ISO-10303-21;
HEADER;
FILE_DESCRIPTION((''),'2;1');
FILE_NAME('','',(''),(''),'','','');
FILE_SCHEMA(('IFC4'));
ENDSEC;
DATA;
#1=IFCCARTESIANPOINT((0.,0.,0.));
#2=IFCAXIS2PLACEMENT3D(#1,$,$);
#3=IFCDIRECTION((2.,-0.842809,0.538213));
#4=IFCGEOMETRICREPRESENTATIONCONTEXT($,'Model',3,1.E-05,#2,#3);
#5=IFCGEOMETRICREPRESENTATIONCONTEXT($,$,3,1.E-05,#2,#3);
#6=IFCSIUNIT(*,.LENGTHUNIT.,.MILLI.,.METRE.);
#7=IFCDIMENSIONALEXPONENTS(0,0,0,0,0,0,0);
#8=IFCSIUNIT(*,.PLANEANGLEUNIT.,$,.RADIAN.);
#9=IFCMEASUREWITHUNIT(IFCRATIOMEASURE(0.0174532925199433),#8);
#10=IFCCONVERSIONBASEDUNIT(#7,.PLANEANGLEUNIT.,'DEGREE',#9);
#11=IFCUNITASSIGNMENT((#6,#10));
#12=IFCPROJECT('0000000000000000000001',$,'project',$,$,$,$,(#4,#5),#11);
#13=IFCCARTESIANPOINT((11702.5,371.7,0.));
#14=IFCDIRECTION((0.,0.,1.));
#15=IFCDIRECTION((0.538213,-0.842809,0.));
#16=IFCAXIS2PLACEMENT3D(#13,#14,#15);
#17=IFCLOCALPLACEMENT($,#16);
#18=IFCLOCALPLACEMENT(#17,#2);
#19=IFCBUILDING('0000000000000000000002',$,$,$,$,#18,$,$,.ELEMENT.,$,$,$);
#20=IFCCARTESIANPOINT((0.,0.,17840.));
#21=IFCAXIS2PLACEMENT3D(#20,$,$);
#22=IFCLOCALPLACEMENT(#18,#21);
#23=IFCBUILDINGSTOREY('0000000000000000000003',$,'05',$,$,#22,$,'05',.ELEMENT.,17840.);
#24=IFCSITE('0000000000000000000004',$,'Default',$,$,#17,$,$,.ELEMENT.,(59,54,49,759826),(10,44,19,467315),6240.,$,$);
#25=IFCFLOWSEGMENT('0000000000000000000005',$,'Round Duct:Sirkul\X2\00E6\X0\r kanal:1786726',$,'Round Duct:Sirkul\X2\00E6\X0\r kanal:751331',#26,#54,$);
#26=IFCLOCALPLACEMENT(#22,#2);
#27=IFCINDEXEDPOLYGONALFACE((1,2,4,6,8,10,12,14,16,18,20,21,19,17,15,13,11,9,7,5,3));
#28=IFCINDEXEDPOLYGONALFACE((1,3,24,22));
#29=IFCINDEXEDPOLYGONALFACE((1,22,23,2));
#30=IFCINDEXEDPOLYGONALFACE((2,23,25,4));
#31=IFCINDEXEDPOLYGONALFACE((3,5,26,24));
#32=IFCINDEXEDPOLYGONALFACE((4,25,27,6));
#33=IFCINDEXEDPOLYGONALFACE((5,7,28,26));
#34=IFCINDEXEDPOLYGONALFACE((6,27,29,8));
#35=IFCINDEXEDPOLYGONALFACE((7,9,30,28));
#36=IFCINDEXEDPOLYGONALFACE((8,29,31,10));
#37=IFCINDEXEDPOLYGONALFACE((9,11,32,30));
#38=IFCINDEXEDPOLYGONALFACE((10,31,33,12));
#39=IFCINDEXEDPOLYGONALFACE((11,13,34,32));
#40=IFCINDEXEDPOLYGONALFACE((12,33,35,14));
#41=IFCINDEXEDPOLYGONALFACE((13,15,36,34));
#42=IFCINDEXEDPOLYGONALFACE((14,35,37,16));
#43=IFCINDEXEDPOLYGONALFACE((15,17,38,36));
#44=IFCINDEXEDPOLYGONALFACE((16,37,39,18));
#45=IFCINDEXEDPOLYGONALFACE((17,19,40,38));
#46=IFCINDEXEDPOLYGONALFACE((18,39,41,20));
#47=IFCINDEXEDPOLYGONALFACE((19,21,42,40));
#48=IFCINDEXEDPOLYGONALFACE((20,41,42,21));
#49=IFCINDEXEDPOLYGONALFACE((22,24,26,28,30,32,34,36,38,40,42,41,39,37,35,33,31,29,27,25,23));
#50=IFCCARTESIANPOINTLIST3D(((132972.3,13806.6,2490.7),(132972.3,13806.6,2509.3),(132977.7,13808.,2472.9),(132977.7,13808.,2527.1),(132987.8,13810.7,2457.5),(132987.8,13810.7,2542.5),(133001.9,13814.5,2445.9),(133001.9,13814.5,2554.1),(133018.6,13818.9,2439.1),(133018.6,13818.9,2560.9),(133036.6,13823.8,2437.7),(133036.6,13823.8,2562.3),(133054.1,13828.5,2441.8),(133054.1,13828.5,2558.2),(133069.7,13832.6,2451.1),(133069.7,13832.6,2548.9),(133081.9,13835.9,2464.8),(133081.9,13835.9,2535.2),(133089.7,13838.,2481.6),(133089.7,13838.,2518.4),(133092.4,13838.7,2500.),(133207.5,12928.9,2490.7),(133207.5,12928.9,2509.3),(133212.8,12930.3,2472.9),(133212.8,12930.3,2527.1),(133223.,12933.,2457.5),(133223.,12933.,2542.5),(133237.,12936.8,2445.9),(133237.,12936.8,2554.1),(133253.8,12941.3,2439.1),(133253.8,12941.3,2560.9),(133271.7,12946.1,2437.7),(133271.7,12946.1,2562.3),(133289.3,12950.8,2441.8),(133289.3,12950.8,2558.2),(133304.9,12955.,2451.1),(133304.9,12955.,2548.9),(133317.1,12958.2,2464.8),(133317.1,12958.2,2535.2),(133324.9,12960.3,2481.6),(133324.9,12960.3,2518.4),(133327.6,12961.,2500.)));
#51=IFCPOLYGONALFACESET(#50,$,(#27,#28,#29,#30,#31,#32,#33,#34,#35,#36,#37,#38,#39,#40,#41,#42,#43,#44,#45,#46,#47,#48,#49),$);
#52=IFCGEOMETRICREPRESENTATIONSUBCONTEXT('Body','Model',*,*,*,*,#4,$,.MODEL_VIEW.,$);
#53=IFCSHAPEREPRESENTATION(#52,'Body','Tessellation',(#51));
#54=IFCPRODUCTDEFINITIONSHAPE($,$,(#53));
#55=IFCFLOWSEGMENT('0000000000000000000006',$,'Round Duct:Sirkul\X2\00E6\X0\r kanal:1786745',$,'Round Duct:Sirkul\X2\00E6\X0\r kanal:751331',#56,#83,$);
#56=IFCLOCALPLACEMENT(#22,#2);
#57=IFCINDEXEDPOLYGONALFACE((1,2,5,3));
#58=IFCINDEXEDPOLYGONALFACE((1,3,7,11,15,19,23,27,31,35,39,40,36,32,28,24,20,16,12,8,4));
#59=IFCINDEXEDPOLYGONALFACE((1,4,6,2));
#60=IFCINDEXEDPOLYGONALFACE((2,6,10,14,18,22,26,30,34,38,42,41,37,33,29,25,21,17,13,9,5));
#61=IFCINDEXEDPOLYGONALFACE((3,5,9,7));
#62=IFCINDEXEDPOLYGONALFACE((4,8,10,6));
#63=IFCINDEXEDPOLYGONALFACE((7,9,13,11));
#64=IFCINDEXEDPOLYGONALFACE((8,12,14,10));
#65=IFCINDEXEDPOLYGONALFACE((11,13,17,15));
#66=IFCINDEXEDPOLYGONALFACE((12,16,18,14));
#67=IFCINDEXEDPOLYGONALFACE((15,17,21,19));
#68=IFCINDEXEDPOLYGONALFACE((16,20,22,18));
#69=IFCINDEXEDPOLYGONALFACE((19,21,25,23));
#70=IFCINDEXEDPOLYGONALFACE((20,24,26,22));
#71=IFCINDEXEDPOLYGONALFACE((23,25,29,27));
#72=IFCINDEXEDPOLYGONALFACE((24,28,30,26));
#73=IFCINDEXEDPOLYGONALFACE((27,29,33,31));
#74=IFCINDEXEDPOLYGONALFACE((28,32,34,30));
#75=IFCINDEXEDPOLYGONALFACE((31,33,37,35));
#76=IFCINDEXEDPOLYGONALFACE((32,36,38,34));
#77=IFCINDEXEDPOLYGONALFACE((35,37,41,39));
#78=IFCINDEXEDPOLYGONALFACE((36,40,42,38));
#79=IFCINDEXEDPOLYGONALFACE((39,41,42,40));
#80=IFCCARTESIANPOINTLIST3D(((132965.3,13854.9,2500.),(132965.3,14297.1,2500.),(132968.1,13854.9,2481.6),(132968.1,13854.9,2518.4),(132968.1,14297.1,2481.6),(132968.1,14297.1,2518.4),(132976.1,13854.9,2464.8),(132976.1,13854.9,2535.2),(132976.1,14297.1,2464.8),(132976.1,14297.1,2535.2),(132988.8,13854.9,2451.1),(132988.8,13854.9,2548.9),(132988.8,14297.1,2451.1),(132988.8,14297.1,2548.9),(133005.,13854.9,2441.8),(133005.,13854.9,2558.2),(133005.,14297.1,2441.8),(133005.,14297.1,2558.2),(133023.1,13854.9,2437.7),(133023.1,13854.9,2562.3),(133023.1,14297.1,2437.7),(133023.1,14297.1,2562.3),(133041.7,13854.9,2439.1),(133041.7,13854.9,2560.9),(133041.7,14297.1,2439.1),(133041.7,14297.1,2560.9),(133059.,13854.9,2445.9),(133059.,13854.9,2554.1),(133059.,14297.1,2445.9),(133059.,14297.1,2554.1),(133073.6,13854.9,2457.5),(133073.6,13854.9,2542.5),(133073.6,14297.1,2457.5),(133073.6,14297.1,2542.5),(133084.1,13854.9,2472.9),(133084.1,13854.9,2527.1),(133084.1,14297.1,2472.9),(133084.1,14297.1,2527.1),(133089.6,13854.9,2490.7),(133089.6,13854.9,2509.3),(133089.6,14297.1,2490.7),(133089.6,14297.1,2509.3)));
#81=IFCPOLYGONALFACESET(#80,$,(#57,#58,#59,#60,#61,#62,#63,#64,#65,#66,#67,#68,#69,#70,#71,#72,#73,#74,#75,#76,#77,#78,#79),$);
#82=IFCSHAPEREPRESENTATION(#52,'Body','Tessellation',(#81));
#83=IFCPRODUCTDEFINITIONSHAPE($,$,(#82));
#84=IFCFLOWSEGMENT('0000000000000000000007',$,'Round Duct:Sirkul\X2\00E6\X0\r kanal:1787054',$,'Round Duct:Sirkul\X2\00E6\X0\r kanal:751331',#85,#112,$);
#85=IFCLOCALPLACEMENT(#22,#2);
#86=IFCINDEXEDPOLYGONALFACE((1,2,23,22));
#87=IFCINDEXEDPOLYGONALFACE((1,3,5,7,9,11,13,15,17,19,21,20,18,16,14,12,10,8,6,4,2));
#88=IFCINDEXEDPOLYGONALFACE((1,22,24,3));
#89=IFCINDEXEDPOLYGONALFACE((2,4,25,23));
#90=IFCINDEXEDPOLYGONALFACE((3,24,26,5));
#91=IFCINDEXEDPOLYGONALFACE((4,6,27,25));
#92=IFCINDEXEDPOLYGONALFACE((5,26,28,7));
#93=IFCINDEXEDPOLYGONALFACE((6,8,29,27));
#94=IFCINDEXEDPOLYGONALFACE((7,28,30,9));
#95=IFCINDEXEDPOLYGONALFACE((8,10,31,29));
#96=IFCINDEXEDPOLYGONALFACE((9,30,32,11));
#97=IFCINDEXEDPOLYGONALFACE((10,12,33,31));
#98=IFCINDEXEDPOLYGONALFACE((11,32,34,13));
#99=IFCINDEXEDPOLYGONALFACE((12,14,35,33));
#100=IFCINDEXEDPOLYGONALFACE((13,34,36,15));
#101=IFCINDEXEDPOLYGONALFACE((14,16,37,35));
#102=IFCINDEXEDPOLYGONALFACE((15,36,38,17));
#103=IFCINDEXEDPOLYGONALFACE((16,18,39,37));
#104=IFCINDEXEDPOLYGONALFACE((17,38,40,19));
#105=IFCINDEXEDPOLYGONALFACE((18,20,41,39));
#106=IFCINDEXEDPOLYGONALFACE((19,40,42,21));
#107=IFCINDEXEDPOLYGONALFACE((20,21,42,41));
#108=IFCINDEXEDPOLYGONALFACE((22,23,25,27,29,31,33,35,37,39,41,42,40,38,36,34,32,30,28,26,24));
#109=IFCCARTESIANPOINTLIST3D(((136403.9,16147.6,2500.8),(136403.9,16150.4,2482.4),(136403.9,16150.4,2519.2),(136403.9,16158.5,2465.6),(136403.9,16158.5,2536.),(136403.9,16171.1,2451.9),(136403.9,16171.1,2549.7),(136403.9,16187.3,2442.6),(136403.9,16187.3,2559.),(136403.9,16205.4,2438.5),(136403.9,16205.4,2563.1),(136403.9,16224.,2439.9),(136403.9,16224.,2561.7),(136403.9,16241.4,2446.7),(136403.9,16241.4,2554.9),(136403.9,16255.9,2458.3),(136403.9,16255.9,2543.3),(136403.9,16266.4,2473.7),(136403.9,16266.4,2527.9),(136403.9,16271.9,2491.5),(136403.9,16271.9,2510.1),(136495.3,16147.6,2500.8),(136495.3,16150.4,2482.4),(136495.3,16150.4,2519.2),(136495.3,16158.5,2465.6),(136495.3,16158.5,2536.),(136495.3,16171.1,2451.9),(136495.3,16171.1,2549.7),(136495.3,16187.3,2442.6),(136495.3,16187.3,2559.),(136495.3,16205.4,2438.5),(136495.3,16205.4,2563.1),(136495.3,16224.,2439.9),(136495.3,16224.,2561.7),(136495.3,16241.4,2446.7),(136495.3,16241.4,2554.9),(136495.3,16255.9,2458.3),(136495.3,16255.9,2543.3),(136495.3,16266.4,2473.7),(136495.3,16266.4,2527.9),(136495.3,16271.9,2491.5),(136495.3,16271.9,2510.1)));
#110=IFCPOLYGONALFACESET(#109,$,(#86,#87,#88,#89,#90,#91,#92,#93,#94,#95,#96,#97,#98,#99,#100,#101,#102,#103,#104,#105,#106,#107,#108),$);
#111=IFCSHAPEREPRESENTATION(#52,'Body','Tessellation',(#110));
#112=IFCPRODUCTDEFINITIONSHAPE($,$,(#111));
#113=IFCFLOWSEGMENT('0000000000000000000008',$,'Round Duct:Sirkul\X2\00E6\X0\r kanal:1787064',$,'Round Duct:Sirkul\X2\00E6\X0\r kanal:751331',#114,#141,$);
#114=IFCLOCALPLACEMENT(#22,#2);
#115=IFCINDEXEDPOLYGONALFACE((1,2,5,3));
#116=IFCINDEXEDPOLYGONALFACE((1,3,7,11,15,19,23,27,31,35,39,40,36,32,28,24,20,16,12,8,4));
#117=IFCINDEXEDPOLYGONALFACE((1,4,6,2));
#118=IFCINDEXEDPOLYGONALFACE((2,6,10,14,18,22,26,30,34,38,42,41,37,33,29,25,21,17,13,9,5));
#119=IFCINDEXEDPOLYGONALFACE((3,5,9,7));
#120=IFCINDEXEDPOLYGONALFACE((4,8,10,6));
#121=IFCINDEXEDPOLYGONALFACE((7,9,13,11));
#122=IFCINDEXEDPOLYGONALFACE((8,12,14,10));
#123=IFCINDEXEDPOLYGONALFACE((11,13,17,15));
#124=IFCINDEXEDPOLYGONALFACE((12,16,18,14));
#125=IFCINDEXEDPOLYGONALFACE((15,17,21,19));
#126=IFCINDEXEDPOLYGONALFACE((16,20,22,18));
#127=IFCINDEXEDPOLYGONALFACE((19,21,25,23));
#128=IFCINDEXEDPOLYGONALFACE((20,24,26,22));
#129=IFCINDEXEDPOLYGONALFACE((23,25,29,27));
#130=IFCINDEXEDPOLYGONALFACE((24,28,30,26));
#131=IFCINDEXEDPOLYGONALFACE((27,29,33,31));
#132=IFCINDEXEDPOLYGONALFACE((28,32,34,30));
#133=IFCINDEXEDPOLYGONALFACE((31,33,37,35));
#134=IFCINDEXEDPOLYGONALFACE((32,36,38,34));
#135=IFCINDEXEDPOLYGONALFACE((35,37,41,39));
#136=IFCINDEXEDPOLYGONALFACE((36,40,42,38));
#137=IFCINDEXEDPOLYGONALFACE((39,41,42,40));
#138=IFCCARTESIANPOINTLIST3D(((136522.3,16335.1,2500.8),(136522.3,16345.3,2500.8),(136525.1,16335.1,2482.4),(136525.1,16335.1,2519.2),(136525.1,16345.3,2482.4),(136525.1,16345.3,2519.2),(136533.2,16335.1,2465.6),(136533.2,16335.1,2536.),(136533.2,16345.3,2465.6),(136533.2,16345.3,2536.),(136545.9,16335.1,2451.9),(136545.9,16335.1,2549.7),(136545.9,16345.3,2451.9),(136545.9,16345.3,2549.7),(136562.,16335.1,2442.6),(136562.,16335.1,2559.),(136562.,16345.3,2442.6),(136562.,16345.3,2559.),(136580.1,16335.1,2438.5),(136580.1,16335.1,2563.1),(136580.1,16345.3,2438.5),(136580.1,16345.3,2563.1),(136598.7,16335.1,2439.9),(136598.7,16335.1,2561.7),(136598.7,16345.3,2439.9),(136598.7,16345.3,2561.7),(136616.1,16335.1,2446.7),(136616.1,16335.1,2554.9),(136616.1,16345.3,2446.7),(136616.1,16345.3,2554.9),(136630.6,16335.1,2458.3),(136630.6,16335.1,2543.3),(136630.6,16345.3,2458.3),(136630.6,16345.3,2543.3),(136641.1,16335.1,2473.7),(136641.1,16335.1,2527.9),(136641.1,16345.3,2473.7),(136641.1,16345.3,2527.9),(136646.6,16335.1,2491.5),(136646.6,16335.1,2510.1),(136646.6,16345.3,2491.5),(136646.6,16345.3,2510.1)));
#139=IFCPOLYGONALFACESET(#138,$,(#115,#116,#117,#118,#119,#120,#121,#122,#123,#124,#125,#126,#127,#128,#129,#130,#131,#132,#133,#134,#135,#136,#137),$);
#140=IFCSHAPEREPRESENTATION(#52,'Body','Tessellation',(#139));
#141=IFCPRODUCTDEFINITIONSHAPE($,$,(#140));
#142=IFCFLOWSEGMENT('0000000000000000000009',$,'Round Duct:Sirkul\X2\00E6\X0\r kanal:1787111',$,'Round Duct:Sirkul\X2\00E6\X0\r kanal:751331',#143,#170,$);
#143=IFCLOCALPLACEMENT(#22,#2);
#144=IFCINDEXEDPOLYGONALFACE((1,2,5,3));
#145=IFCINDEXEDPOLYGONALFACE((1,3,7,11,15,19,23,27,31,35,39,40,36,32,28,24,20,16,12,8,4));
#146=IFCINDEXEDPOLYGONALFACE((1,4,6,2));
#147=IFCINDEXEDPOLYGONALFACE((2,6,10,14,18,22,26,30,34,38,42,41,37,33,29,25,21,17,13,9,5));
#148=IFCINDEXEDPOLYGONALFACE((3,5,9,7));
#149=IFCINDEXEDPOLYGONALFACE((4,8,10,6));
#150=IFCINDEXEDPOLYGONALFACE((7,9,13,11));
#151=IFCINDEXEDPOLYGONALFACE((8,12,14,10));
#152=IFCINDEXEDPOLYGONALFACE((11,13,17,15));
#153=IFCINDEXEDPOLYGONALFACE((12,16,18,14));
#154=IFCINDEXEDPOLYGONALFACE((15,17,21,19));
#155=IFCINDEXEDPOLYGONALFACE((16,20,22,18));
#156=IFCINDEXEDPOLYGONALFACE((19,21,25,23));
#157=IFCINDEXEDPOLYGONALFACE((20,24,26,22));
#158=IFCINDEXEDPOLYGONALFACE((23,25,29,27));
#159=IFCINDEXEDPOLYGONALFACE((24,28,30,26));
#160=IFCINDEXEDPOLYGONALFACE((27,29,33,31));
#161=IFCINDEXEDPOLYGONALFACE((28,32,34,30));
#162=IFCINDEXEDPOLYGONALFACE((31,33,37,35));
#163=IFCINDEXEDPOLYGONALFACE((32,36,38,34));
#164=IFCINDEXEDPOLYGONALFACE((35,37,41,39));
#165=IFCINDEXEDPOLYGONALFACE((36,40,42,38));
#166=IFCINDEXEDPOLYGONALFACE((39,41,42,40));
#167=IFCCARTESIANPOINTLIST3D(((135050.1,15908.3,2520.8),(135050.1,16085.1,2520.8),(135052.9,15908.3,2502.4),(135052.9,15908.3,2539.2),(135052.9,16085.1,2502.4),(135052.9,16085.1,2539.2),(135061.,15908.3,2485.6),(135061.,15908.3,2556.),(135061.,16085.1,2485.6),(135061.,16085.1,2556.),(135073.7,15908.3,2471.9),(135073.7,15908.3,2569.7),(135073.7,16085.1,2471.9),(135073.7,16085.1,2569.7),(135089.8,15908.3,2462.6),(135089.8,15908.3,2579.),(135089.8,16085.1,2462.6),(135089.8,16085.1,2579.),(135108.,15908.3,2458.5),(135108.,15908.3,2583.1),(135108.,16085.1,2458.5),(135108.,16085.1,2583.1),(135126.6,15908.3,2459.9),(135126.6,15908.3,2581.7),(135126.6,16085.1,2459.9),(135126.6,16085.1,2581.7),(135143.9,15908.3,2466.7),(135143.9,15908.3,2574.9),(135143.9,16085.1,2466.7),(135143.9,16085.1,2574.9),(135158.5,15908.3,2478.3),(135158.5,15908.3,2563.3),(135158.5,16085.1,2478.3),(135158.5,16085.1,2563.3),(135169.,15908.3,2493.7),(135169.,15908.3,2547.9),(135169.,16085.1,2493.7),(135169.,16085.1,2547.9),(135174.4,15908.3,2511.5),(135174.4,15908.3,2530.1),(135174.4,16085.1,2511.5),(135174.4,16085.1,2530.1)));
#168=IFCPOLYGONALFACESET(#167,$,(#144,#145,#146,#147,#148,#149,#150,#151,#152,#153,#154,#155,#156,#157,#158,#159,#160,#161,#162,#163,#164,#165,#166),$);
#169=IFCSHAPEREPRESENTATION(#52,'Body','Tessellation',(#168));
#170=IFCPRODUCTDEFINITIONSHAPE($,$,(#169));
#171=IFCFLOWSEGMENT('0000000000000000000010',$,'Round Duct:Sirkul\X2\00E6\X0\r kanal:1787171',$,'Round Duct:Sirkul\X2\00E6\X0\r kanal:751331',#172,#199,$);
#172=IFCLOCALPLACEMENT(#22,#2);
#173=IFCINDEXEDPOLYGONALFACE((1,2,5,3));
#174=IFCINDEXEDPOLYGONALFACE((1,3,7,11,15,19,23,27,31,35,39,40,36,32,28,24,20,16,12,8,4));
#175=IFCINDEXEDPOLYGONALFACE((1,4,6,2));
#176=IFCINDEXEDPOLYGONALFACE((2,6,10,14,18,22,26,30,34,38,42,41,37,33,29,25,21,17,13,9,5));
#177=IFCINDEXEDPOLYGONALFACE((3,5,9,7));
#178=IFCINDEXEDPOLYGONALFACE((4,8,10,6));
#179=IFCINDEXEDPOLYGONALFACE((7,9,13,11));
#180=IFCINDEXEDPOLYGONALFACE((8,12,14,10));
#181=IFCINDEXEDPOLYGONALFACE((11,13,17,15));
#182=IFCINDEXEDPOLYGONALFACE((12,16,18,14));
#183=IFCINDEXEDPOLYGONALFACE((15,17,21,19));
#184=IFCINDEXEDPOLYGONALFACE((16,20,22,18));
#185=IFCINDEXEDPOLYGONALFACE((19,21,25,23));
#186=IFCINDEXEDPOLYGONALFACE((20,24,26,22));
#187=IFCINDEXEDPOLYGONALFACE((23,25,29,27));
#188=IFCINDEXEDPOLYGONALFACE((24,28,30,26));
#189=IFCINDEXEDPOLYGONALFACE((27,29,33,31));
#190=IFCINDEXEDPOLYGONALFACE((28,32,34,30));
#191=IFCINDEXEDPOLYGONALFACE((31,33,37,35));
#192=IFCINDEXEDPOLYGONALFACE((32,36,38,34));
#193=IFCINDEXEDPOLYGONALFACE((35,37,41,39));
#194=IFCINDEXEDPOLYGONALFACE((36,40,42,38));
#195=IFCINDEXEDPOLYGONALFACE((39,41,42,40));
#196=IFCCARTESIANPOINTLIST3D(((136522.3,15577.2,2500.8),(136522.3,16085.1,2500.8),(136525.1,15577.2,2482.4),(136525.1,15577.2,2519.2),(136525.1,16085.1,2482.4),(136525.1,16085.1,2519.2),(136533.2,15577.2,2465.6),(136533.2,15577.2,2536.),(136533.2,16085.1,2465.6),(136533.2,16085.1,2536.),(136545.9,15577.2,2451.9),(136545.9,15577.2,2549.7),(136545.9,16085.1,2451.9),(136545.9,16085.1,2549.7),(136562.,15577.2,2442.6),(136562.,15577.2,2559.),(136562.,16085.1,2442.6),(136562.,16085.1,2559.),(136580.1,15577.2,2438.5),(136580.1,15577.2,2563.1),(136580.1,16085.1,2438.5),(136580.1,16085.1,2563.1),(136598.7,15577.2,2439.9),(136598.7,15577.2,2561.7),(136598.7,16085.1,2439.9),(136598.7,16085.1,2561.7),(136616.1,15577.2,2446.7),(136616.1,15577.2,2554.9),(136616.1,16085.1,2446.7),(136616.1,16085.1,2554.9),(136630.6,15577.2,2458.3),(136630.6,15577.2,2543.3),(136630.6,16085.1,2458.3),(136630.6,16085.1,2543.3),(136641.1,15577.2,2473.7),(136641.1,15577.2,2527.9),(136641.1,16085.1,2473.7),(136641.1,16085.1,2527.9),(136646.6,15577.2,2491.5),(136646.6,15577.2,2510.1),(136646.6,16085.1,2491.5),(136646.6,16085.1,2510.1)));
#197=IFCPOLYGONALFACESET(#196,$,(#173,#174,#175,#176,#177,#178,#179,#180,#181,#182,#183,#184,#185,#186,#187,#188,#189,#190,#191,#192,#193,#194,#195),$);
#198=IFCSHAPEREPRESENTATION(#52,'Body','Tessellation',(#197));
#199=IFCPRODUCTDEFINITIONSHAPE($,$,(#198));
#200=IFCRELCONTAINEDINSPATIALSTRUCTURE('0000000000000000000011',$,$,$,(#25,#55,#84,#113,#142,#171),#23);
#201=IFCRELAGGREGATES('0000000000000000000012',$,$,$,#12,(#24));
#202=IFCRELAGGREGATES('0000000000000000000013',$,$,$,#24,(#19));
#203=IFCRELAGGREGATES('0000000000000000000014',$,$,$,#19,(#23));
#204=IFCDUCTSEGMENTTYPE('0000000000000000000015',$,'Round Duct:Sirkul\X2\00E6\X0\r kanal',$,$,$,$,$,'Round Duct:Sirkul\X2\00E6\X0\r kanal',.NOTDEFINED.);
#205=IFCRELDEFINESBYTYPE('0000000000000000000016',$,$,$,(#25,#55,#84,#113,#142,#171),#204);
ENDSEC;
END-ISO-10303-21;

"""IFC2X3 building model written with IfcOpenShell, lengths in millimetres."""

from ifc_helpers import new_model, entity, si_unit, converted_unit, direction, frame, frame_2d, origin, origin_2d_with_axis, place, context, subcontext, project, spatial, circle, extrude, type_object, element, save


model = new_model("IFC2X3")

# Units and contexts
model_context = context("Model", 3, precision=1e-05, world=origin(), true_north=direction((2.0, -0.842809, 0.538213)))
context_of_model = context(None, 3, precision=1e-05, world=origin(), true_north=direction((2.0, -0.842809, 0.538213)))
body_context = subcontext(model_context, "Body", "Model", "MODEL_VIEW")
ifc_project = project(units=[si_unit("LENGTHUNIT", "METRE", prefix="MILLI"), converted_unit("PLANEANGLEUNIT", "DEGREE", entity("IfcRatioMeasure", 0.0174532925199433), si_unit("PLANEANGLEUNIT", "RADIAN"), dimensions=[0, 0, 0, 0, 0, 0, 0])], contexts=[model_context, context_of_model])

# Site, building, storey
site_placement = place(None, frame((11702.5, 371.7, 0.0), z_axis=(0.0, 0.0, 1.0), x_axis=(0.538213, -0.842809, 0.0)))
site = spatial("IfcSite", under=ifc_project, at=site_placement, Name="Default", CompositionType="ELEMENT", RefLatitude=(59, 54, 49, 759826), RefLongitude=(10, 44, 19, 467315), RefElevation=6240.0)
building_placement = place(site_placement, origin())
building = spatial("IfcBuilding", under=site, at=building_placement, CompositionType="ELEMENT")
storey_placement = place(building_placement, frame((0.0, 0.0, 17840.0)))
storey = spatial("IfcBuildingStorey", under=building, at=storey_placement, Name="05", LongName="05", CompositionType="ELEMENT", Elevation=17840.0)

# Flow segments
duct_segment_type_1 = type_object("IfcDuctSegmentType", Name="Round Duct:Sirkulær kanal", ElementType="Round Duct:Sirkulær kanal", PredefinedType="NOTDEFINED")
flow_segment_1_placement = place(storey_placement, origin())
element("IfcFlowSegment", 1, at=flow_segment_1_placement, inside=storey, type_object=duct_segment_type_1, Name="Round Duct:Sirkulær kanal:1786726", ObjectType="Round Duct:Sirkulær kanal:751331", context=body_context, shape_type="SweptSolid", body=[
    extrude(circle(Radius=62.5, at=origin_2d_with_axis()), frame((133267.2, 12944.9, 2500.0), z_axis=(-0.258819, 0.965926, 0.0), x_axis=(0.965926, 0.258819, 0.0)), (0.0, 0.0, 1.0), 908.6),
])
flow_segment_2_placement = place(storey_placement, origin())
element("IfcFlowSegment", 2, at=flow_segment_2_placement, inside=storey, type_object=duct_segment_type_1, Name="Round Duct:Sirkulær kanal:1786745", ObjectType="Round Duct:Sirkulær kanal:751331", context=body_context, shape_type="SweptSolid", body=[
    extrude(circle(Radius=62.5, at=origin_2d_with_axis()), frame((133027.8, 13854.9, 2500.0), z_axis=(0.0, 1.0, 0.0), x_axis=(-1.0, 0.0, 0.0)), (0.0, 0.0, 1.0), 442.2),
])
flow_segment_3_placement = place(storey_placement, origin())
element("IfcFlowSegment", 3, at=flow_segment_3_placement, inside=storey, type_object=duct_segment_type_1, Name="Round Duct:Sirkulær kanal:1787054", ObjectType="Round Duct:Sirkulær kanal:751331", context=body_context, shape_type="SweptSolid", body=[
    extrude(circle(Radius=62.5, at=origin_2d_with_axis()), frame((136403.9, 16210.1, 2500.8), z_axis=(1.0, 0.0, 0.0), x_axis=(0.0, -1.0, 0.0)), (0.0, 0.0, 1.0), 91.4),
])
flow_segment_4_placement = place(storey_placement, origin())
element("IfcFlowSegment", 4, at=flow_segment_4_placement, inside=storey, type_object=duct_segment_type_1, Name="Round Duct:Sirkulær kanal:1787064", ObjectType="Round Duct:Sirkulær kanal:751331", context=body_context, shape_type="SweptSolid", body=[
    extrude(circle(Radius=62.5, at=frame_2d((0.0, 0.0), x_axis=(1.0, 0.0))), frame((136584.8, 16335.1, 2500.8), z_axis=(0.0, 1.0, 0.0), x_axis=(-1.0, 0.0, 0.0)), (0.0, 0.0, 1.0), 10.2),
])
flow_segment_5_placement = place(storey_placement, origin())
element("IfcFlowSegment", 5, at=flow_segment_5_placement, inside=storey, type_object=duct_segment_type_1, Name="Round Duct:Sirkulær kanal:1787111", ObjectType="Round Duct:Sirkulær kanal:751331", context=body_context, shape_type="SweptSolid", body=[
    extrude(circle(Radius=62.5, at=origin_2d_with_axis()), frame((135112.6, 15908.3, 2520.8), z_axis=(0.0, 1.0, 0.0), x_axis=(-1.0, 0.0, 0.0)), (0.0, 0.0, 1.0), 176.8),
])
flow_segment_6_placement = place(storey_placement, origin())
element("IfcFlowSegment", 6, at=flow_segment_6_placement, inside=storey, type_object=duct_segment_type_1, Name="Round Duct:Sirkulær kanal:1787171", ObjectType="Round Duct:Sirkulær kanal:751331", context=body_context, shape_type="SweptSolid", body=[
    extrude(circle(Radius=62.5, at=origin_2d_with_axis()), frame((136584.8, 15577.2, 2500.8), z_axis=(0.0, 1.0, 0.0), x_axis=(-1.0, 0.0, 0.0)), (0.0, 0.0, 1.0), 507.9),
])

save(model, "model.ifc")
